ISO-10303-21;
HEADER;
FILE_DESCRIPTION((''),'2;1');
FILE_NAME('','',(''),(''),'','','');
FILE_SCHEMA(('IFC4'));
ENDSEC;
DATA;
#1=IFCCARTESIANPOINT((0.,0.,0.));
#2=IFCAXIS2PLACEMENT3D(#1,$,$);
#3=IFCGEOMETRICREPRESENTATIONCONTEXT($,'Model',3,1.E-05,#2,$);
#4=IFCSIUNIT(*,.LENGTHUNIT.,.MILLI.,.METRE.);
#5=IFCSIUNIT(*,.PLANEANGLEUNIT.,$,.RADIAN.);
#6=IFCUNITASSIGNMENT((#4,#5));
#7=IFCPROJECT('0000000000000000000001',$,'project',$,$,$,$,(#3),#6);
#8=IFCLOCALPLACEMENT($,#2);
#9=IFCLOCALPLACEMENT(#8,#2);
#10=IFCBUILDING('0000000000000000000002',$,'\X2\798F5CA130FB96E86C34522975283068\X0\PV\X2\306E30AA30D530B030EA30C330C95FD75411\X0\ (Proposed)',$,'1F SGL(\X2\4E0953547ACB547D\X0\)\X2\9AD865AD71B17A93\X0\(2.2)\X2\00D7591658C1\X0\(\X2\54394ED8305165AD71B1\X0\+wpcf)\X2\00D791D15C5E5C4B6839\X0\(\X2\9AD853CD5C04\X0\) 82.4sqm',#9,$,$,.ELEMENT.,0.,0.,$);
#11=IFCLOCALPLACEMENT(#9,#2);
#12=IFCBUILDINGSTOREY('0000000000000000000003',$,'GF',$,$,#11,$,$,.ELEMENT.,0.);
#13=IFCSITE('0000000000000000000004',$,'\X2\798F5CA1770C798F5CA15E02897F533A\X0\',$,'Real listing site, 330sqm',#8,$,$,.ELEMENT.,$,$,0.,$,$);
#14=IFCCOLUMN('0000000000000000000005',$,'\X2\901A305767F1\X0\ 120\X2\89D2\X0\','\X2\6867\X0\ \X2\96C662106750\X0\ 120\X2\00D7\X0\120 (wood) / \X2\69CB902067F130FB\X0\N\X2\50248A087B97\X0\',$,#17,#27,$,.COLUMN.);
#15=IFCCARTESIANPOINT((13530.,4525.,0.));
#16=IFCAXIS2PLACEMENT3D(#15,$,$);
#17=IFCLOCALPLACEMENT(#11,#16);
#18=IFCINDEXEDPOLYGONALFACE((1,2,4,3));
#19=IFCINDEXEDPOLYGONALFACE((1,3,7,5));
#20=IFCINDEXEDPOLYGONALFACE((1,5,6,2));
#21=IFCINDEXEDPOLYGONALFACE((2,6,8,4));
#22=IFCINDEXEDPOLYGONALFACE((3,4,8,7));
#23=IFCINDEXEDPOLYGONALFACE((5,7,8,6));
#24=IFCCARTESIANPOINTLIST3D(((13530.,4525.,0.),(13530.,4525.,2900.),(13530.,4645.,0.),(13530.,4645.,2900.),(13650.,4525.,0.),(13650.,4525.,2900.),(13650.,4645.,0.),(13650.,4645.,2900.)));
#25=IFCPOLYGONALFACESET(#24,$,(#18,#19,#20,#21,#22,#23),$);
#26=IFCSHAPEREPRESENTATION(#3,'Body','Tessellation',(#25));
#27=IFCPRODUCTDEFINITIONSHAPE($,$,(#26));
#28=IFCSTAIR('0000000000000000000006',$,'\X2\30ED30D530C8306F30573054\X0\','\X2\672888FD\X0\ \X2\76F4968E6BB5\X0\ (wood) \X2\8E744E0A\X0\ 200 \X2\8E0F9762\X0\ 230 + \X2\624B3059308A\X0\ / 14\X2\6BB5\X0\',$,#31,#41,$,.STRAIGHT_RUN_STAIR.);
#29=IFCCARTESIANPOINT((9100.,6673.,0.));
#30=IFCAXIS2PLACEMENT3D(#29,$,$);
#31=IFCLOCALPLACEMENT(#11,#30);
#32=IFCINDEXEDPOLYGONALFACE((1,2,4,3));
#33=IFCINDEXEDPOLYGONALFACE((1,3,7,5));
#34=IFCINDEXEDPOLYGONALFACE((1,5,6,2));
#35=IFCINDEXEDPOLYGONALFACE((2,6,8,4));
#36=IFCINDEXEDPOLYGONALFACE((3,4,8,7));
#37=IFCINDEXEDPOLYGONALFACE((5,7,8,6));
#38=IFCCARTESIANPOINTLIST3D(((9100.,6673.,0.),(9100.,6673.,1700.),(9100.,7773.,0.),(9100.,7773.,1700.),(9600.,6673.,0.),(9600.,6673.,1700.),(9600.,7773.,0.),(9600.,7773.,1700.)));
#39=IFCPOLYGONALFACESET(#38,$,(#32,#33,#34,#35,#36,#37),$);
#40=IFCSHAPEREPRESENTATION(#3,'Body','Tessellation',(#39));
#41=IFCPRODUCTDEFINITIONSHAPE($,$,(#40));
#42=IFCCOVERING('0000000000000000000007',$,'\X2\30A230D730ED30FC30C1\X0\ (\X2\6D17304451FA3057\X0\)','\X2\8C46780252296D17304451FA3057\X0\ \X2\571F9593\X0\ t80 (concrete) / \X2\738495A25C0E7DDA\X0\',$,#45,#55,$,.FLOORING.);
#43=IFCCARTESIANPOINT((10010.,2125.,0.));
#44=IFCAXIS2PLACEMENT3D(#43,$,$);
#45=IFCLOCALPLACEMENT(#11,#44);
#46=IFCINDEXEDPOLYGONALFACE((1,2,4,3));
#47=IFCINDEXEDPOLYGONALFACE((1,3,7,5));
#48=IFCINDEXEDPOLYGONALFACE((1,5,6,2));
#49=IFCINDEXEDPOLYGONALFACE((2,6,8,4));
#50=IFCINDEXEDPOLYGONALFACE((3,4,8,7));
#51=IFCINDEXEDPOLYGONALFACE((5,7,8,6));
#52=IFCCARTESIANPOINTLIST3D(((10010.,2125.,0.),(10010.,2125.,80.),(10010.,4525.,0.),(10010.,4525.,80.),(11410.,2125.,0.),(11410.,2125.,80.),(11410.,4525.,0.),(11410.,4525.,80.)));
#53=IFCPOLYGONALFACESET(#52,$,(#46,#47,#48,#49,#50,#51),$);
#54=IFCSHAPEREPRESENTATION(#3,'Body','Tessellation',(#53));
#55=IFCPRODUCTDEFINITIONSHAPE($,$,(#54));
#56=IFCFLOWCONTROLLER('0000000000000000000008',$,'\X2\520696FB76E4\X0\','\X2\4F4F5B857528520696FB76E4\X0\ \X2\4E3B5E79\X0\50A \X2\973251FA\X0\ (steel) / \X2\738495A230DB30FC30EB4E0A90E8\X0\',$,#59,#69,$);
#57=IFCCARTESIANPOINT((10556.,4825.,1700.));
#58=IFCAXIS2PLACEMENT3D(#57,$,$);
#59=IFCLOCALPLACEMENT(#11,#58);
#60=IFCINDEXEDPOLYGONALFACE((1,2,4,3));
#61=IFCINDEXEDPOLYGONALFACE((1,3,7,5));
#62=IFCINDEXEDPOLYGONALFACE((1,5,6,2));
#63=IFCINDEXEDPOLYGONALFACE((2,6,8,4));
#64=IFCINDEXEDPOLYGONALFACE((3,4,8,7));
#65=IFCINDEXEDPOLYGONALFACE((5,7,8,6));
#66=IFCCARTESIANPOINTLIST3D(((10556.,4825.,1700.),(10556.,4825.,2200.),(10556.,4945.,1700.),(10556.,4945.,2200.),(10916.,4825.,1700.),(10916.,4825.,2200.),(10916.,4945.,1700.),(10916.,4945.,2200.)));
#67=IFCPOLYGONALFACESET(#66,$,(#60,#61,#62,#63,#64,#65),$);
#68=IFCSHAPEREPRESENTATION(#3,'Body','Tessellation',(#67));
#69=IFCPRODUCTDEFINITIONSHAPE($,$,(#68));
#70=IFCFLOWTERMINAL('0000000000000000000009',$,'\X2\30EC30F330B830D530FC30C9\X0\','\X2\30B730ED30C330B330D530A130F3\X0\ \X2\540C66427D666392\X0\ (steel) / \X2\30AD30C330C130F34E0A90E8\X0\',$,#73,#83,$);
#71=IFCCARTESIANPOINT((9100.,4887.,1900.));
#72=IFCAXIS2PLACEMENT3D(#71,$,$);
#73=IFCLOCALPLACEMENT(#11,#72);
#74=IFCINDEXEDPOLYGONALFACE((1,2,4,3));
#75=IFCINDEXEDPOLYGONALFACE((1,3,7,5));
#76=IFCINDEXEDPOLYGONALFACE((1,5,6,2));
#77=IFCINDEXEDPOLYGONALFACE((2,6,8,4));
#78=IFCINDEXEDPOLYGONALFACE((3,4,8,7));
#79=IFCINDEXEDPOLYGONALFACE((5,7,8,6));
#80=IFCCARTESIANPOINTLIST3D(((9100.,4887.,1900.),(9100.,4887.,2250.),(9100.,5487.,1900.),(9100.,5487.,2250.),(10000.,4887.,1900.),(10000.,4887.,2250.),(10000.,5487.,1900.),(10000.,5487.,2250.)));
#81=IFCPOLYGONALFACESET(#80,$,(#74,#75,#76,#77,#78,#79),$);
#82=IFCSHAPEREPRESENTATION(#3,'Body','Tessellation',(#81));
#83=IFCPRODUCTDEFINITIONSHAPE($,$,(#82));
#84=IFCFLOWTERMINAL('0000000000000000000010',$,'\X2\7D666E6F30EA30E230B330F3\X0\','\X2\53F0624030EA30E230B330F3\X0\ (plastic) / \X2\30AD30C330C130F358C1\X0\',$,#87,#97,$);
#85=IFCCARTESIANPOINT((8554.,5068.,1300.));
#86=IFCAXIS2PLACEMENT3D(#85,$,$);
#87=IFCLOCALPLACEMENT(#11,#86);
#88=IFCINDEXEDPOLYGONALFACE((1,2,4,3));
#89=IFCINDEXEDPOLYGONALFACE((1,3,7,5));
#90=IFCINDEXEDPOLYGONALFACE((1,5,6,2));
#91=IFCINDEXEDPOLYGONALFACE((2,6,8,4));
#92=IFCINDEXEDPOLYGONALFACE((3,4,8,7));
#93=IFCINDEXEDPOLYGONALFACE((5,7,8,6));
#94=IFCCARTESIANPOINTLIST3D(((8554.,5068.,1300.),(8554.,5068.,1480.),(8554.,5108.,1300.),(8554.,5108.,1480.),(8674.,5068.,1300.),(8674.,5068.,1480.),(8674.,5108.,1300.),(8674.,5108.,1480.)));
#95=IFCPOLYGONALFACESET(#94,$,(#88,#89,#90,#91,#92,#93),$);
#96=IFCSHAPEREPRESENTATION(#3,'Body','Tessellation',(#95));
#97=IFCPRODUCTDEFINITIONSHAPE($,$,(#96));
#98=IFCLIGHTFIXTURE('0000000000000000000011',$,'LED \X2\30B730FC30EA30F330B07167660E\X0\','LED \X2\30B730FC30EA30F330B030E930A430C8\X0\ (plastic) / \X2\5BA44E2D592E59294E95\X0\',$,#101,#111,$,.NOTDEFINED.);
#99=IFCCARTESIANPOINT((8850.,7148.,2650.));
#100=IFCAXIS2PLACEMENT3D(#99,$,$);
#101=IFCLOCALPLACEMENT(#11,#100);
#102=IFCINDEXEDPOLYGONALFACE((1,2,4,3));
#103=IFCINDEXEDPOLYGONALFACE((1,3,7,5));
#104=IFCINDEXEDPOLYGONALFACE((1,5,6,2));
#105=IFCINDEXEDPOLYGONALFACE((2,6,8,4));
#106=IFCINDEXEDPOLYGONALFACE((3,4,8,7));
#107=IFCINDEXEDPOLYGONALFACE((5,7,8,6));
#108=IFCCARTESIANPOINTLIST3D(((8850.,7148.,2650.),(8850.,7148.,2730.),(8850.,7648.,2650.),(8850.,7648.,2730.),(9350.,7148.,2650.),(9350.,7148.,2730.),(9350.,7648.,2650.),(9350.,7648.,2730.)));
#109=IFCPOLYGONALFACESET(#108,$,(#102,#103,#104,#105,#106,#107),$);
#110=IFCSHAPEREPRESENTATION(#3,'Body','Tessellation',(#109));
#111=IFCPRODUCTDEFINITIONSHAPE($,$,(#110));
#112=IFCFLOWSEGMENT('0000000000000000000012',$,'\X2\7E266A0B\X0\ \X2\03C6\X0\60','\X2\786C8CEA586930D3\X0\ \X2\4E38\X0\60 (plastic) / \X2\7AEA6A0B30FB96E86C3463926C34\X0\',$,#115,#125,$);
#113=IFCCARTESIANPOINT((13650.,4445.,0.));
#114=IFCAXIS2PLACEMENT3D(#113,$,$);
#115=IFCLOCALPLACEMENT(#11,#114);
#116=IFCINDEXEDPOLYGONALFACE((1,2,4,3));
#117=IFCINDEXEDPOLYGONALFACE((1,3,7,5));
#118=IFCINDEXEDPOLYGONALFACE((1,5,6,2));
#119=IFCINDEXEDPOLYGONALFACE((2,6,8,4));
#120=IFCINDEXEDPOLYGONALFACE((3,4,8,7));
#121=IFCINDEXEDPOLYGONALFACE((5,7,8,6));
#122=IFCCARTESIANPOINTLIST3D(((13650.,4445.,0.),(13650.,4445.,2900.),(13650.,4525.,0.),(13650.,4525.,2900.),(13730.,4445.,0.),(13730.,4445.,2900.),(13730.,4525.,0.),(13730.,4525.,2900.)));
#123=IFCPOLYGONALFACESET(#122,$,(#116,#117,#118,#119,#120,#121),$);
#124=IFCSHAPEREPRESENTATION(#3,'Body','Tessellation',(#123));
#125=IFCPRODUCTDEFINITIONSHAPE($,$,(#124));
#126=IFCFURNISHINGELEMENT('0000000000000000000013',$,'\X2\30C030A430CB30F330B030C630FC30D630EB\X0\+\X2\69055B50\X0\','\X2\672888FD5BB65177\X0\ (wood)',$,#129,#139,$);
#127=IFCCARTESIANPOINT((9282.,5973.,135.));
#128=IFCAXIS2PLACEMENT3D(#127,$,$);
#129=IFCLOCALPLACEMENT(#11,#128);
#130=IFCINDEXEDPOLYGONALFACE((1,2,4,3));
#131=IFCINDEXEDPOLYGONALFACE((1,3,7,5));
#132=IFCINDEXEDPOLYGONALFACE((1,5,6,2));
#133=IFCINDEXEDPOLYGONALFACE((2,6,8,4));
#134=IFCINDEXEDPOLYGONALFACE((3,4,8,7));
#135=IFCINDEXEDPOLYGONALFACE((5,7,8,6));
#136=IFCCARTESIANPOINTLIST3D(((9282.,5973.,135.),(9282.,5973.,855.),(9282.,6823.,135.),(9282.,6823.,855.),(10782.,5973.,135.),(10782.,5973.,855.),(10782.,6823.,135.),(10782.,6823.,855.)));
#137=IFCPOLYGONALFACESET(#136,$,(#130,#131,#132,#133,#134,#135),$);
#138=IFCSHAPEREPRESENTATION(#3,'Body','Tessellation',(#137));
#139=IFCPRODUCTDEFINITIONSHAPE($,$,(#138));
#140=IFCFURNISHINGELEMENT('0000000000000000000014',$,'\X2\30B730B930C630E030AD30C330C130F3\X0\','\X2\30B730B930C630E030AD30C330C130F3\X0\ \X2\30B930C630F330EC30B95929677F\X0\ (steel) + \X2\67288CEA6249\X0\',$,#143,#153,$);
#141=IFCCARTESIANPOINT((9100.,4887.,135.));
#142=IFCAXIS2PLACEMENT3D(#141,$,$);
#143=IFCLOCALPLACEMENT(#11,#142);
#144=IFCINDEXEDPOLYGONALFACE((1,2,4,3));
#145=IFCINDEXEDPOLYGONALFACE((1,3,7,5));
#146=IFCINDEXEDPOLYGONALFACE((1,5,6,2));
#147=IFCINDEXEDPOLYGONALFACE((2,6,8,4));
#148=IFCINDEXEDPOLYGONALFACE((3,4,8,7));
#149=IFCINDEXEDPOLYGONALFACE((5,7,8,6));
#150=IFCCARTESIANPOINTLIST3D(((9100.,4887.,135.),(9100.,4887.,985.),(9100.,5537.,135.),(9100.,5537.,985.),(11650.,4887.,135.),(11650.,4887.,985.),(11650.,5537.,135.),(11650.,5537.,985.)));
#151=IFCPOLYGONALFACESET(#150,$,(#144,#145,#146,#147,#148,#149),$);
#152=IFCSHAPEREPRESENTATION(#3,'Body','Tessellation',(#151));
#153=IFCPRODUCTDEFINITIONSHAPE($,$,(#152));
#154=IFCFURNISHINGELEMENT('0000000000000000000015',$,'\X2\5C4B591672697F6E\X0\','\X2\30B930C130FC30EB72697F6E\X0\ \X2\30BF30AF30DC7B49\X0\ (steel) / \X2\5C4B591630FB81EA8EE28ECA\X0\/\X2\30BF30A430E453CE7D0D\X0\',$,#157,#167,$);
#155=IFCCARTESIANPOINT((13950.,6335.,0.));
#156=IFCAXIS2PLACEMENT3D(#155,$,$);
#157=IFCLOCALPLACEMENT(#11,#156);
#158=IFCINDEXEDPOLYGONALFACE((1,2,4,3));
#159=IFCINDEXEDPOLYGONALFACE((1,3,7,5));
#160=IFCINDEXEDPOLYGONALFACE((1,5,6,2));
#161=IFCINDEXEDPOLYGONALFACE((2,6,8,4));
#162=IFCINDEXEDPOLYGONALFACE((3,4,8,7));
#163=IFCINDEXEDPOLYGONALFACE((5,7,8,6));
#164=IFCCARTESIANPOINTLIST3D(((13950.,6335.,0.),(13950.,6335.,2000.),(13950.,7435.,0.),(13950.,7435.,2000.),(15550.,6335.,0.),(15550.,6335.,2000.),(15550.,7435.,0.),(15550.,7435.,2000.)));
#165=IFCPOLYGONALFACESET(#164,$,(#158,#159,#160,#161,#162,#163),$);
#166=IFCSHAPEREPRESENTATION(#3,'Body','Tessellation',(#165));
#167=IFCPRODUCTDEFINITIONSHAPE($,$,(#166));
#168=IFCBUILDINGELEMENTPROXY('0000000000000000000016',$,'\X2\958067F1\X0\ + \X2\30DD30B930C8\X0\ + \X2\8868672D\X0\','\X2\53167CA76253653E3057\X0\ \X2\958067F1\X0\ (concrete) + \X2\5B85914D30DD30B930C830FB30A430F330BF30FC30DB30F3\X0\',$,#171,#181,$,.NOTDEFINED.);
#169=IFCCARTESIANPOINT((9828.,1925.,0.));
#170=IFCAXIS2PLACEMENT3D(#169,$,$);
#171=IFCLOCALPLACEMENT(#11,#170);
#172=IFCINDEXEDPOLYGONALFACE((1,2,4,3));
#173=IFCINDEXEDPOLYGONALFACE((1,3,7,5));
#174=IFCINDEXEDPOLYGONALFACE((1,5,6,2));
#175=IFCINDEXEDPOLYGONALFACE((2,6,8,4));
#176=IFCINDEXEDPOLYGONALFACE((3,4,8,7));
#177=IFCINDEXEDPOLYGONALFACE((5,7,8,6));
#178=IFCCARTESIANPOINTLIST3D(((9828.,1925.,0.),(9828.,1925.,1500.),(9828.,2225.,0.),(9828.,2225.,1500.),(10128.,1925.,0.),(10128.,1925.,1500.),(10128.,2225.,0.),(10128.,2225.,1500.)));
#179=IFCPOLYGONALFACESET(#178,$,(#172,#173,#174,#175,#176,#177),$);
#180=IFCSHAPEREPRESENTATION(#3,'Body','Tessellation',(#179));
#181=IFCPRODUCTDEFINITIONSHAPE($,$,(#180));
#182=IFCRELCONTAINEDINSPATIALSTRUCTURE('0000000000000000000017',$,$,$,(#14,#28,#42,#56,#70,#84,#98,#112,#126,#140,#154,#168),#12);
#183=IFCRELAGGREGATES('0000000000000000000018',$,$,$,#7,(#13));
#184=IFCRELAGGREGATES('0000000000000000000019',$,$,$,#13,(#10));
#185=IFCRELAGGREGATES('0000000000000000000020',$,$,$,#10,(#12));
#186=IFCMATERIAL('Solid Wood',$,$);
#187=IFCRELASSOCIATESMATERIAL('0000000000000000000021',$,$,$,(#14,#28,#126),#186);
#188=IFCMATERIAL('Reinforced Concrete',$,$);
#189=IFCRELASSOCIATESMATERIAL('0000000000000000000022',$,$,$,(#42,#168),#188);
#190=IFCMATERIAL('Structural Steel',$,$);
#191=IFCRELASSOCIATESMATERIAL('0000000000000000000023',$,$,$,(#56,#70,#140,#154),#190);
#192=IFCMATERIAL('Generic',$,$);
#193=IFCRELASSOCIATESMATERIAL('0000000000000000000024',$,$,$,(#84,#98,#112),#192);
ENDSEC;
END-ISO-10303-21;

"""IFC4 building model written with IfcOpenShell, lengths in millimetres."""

from ifc_helpers import new_model, si_unit, frame, frame_2d, origin, place, context, project, spatial, rectangle, extrude, material, element, save


model = new_model("IFC4")

# Units and contexts
model_context = context("Model", 3, precision=1e-05, world=origin())
ifc_project = project(units=[si_unit("LENGTHUNIT", "METRE", prefix="MILLI"), si_unit("PLANEANGLEUNIT", "RADIAN")], contexts=[model_context])

# Site, building, storey
site_placement = place(None, origin())
site = spatial("IfcSite", under=ifc_project, at=site_placement, Name="福岡県福岡市西区", ObjectType="Real listing site, 330sqm", CompositionType="ELEMENT", RefElevation=0.0)
building_placement = place(site_placement, origin())
building = spatial("IfcBuilding", under=site, at=building_placement, Name="福岡・雨水利用とPVのオフグリッド志向 (Proposed)", ObjectType="1F SGL(三協立命)高断熱窓(2.2)×外壁(吹付け断熱+wpcf)×金属屋根(高反射) 82.4sqm", CompositionType="ELEMENT", ElevationOfRefHeight=0.0, ElevationOfTerrain=0.0)
storey_placement = place(building_placement, origin())
storey = spatial("IfcBuildingStorey", under=building, at=storey_placement, Name="GF", CompositionType="ELEMENT", Elevation=0.0)

# Column
ifc_material_1 = material(Name="Solid Wood")
column_1_placement = place(storey_placement, frame((13530.0, 4525.0, 0.0)))
element("IfcColumn", 1, at=column_1_placement, inside=storey, material=ifc_material_1, Name="通し柱 120角", Description="桧 集成材 120×120 (wood) / 構造柱・N値計算", PredefinedType="COLUMN", context=model_context, shape_type="SweptSolid", body=[
    extrude(rectangle(XDim=120.0, YDim=120.0, at=frame_2d((60.0, 60.0))), frame((13530.0, 4525.0, 0.0)), (0.0, 0.0, 1.0), 2900.0),
])

# Stair
stair_placement = place(storey_placement, frame((9100.0, 6673.0, 0.0)))
element("IfcStair", 2, at=stair_placement, inside=storey, material=ifc_material_1, Name="ロフトはしご", Description="木製 直階段 (wood) 蹴上 200 踏面 230 + 手すり / 14段", PredefinedType="STRAIGHT_RUN_STAIR", context=model_context, shape_type="SweptSolid", body=[
    extrude(rectangle(XDim=500.0, YDim=1100.0, at=frame_2d((250.0, 550.0))), frame((9100.0, 6673.0, 0.0)), (0.0, 0.0, 1.0), 1700.0),
])

# Covering
ifc_material_2 = material(Name="Reinforced Concrete")
covering_placement = place(storey_placement, frame((10010.0, 2125.0, 0.0)))
element("IfcCovering", 3, at=covering_placement, inside=storey, material=ifc_material_2, Name="アプローチ (洗い出し)", Description="豆砂利洗い出し 土間 t80 (concrete) / 玄関導線", PredefinedType="FLOORING", context=model_context, shape_type="SweptSolid", body=[
    extrude(rectangle(XDim=1400.0, YDim=2400.0, at=frame_2d((700.0, 1200.0))), frame((10010.0, 2125.0, 0.0)), (0.0, 0.0, 1.0), 80.0),
])

# Flow controller
ifc_material_3 = material(Name="Structural Steel")
flow_controller_placement = place(storey_placement, frame((10556.0, 4825.0, 1700.0)))
element("IfcFlowController", 4, at=flow_controller_placement, inside=storey, material=ifc_material_3, Name="分電盤", Description="住宅用分電盤 主幹50A 露出 (steel) / 玄関ホール上部", context=model_context, shape_type="SweptSolid", body=[
    extrude(rectangle(XDim=360.0, YDim=120.0, at=frame_2d((180.0, 60.0))), frame((10556.0, 4825.0, 1700.0)), (0.0, 0.0, 1.0), 500.0),
])

# Flow terminals
flow_terminal_1_placement = place(storey_placement, frame((9100.0, 4887.0, 1900.0)))
element("IfcFlowTerminal", 5, at=flow_terminal_1_placement, inside=storey, material=ifc_material_3, Name="レンジフード", Description="シロッコファン 同時給排 (steel) / キッチン上部", context=model_context, shape_type="SweptSolid", body=[
    extrude(rectangle(XDim=900.0, YDim=600.0, at=frame_2d((450.0, 300.0))), frame((9100.0, 4887.0, 1900.0)), (0.0, 0.0, 1.0), 350.0),
])
ifc_material_4 = material(Name="Generic")
flow_terminal_2_placement = place(storey_placement, frame((8554.0, 5068.0, 1300.0)))
element("IfcFlowTerminal", 6, at=flow_terminal_2_placement, inside=storey, material=ifc_material_4, Name="給湯リモコン", Description="台所リモコン (plastic) / キッチン壁", context=model_context, shape_type="SweptSolid", body=[
    extrude(rectangle(XDim=120.0, YDim=40.0, at=frame_2d((60.0, 20.0))), frame((8554.0, 5068.0, 1300.0)), (0.0, 0.0, 1.0), 180.0),
])

# Light fixture
light_fixture_placement = place(storey_placement, frame((8850.0, 7148.0, 2650.0)))
element("IfcLightFixture", 7, at=light_fixture_placement, inside=storey, material=ifc_material_4, Name="LED シーリング照明", Description="LED シーリングライト (plastic) / 室中央天井", PredefinedType="NOTDEFINED", context=model_context, shape_type="SweptSolid", body=[
    extrude(rectangle(XDim=500.0, YDim=500.0, at=frame_2d((250.0, 250.0))), frame((8850.0, 7148.0, 2650.0)), (0.0, 0.0, 1.0), 80.0),
])

# Flow segment
flow_segment_placement = place(storey_placement, frame((13650.0, 4445.0, 0.0)))
element("IfcFlowSegment", 8, at=flow_segment_placement, inside=storey, material=ifc_material_4, Name="縦樋 φ60", Description="硬質塩ビ 丸60 (plastic) / 竪樋・雨水排水", context=model_context, shape_type="SweptSolid", body=[
    extrude(rectangle(XDim=80.0, YDim=80.0, at=frame_2d((40.0, 40.0))), frame((13650.0, 4445.0, 0.0)), (0.0, 0.0, 1.0), 2900.0),
])

# Furnishing elements
furnishing_1_placement = place(storey_placement, frame((9282.0, 5973.0, 135.0)))
element("IfcFurnishingElement", 9, at=furnishing_1_placement, inside=storey, material=ifc_material_1, Name="ダイニングテーブル+椅子", Description="木製家具 (wood)", context=model_context, shape_type="SweptSolid", body=[
    extrude(rectangle(XDim=1500.0, YDim=850.0, at=frame_2d((750.0, 425.0))), frame((9282.0, 5973.0, 135.0)), (0.0, 0.0, 1.0), 720.0),
])
furnishing_2_placement = place(storey_placement, frame((9100.0, 4887.0, 135.0)))
element("IfcFurnishingElement", 10, at=furnishing_2_placement, inside=storey, material=ifc_material_3, Name="システムキッチン", Description="システムキッチン ステンレス天板 (steel) + 木質扉", context=model_context, shape_type="SweptSolid", body=[
    extrude(rectangle(XDim=2550.0, YDim=650.0, at=frame_2d((1275.0, 325.0))), frame((9100.0, 4887.0, 135.0)), (0.0, 0.0, 1.0), 850.0),
])
furnishing_3_placement = place(storey_placement, frame((13950.0, 6335.0, 0.0)))
element("IfcFurnishingElement", 11, at=furnishing_3_placement, inside=storey, material=ifc_material_3, Name="屋外物置", Description="スチール物置 タクボ等 (steel) / 屋外・自転車/タイヤ収納", context=model_context, shape_type="SweptSolid", body=[
    extrude(rectangle(XDim=1600.0, YDim=1100.0, at=frame_2d((800.0, 550.0))), frame((13950.0, 6335.0, 0.0)), (0.0, 0.0, 1.0), 2000.0),
])

# Building element proxy
proxy_placement = place(storey_placement, frame((9828.0, 1925.0, 0.0)))
element("IfcBuildingElementProxy", 12, at=proxy_placement, inside=storey, material=ifc_material_2, Name="門柱 + ポスト + 表札", Description="化粧打放し 門柱 (concrete) + 宅配ポスト・インターホン", PredefinedType="NOTDEFINED", context=model_context, shape_type="SweptSolid", body=[
    extrude(rectangle(XDim=300.0, YDim=300.0, at=frame_2d((150.0, 150.0))), frame((9828.0, 1925.0, 0.0)), (0.0, 0.0, 1.0), 1500.0),
])

save(model, "model.ifc")
